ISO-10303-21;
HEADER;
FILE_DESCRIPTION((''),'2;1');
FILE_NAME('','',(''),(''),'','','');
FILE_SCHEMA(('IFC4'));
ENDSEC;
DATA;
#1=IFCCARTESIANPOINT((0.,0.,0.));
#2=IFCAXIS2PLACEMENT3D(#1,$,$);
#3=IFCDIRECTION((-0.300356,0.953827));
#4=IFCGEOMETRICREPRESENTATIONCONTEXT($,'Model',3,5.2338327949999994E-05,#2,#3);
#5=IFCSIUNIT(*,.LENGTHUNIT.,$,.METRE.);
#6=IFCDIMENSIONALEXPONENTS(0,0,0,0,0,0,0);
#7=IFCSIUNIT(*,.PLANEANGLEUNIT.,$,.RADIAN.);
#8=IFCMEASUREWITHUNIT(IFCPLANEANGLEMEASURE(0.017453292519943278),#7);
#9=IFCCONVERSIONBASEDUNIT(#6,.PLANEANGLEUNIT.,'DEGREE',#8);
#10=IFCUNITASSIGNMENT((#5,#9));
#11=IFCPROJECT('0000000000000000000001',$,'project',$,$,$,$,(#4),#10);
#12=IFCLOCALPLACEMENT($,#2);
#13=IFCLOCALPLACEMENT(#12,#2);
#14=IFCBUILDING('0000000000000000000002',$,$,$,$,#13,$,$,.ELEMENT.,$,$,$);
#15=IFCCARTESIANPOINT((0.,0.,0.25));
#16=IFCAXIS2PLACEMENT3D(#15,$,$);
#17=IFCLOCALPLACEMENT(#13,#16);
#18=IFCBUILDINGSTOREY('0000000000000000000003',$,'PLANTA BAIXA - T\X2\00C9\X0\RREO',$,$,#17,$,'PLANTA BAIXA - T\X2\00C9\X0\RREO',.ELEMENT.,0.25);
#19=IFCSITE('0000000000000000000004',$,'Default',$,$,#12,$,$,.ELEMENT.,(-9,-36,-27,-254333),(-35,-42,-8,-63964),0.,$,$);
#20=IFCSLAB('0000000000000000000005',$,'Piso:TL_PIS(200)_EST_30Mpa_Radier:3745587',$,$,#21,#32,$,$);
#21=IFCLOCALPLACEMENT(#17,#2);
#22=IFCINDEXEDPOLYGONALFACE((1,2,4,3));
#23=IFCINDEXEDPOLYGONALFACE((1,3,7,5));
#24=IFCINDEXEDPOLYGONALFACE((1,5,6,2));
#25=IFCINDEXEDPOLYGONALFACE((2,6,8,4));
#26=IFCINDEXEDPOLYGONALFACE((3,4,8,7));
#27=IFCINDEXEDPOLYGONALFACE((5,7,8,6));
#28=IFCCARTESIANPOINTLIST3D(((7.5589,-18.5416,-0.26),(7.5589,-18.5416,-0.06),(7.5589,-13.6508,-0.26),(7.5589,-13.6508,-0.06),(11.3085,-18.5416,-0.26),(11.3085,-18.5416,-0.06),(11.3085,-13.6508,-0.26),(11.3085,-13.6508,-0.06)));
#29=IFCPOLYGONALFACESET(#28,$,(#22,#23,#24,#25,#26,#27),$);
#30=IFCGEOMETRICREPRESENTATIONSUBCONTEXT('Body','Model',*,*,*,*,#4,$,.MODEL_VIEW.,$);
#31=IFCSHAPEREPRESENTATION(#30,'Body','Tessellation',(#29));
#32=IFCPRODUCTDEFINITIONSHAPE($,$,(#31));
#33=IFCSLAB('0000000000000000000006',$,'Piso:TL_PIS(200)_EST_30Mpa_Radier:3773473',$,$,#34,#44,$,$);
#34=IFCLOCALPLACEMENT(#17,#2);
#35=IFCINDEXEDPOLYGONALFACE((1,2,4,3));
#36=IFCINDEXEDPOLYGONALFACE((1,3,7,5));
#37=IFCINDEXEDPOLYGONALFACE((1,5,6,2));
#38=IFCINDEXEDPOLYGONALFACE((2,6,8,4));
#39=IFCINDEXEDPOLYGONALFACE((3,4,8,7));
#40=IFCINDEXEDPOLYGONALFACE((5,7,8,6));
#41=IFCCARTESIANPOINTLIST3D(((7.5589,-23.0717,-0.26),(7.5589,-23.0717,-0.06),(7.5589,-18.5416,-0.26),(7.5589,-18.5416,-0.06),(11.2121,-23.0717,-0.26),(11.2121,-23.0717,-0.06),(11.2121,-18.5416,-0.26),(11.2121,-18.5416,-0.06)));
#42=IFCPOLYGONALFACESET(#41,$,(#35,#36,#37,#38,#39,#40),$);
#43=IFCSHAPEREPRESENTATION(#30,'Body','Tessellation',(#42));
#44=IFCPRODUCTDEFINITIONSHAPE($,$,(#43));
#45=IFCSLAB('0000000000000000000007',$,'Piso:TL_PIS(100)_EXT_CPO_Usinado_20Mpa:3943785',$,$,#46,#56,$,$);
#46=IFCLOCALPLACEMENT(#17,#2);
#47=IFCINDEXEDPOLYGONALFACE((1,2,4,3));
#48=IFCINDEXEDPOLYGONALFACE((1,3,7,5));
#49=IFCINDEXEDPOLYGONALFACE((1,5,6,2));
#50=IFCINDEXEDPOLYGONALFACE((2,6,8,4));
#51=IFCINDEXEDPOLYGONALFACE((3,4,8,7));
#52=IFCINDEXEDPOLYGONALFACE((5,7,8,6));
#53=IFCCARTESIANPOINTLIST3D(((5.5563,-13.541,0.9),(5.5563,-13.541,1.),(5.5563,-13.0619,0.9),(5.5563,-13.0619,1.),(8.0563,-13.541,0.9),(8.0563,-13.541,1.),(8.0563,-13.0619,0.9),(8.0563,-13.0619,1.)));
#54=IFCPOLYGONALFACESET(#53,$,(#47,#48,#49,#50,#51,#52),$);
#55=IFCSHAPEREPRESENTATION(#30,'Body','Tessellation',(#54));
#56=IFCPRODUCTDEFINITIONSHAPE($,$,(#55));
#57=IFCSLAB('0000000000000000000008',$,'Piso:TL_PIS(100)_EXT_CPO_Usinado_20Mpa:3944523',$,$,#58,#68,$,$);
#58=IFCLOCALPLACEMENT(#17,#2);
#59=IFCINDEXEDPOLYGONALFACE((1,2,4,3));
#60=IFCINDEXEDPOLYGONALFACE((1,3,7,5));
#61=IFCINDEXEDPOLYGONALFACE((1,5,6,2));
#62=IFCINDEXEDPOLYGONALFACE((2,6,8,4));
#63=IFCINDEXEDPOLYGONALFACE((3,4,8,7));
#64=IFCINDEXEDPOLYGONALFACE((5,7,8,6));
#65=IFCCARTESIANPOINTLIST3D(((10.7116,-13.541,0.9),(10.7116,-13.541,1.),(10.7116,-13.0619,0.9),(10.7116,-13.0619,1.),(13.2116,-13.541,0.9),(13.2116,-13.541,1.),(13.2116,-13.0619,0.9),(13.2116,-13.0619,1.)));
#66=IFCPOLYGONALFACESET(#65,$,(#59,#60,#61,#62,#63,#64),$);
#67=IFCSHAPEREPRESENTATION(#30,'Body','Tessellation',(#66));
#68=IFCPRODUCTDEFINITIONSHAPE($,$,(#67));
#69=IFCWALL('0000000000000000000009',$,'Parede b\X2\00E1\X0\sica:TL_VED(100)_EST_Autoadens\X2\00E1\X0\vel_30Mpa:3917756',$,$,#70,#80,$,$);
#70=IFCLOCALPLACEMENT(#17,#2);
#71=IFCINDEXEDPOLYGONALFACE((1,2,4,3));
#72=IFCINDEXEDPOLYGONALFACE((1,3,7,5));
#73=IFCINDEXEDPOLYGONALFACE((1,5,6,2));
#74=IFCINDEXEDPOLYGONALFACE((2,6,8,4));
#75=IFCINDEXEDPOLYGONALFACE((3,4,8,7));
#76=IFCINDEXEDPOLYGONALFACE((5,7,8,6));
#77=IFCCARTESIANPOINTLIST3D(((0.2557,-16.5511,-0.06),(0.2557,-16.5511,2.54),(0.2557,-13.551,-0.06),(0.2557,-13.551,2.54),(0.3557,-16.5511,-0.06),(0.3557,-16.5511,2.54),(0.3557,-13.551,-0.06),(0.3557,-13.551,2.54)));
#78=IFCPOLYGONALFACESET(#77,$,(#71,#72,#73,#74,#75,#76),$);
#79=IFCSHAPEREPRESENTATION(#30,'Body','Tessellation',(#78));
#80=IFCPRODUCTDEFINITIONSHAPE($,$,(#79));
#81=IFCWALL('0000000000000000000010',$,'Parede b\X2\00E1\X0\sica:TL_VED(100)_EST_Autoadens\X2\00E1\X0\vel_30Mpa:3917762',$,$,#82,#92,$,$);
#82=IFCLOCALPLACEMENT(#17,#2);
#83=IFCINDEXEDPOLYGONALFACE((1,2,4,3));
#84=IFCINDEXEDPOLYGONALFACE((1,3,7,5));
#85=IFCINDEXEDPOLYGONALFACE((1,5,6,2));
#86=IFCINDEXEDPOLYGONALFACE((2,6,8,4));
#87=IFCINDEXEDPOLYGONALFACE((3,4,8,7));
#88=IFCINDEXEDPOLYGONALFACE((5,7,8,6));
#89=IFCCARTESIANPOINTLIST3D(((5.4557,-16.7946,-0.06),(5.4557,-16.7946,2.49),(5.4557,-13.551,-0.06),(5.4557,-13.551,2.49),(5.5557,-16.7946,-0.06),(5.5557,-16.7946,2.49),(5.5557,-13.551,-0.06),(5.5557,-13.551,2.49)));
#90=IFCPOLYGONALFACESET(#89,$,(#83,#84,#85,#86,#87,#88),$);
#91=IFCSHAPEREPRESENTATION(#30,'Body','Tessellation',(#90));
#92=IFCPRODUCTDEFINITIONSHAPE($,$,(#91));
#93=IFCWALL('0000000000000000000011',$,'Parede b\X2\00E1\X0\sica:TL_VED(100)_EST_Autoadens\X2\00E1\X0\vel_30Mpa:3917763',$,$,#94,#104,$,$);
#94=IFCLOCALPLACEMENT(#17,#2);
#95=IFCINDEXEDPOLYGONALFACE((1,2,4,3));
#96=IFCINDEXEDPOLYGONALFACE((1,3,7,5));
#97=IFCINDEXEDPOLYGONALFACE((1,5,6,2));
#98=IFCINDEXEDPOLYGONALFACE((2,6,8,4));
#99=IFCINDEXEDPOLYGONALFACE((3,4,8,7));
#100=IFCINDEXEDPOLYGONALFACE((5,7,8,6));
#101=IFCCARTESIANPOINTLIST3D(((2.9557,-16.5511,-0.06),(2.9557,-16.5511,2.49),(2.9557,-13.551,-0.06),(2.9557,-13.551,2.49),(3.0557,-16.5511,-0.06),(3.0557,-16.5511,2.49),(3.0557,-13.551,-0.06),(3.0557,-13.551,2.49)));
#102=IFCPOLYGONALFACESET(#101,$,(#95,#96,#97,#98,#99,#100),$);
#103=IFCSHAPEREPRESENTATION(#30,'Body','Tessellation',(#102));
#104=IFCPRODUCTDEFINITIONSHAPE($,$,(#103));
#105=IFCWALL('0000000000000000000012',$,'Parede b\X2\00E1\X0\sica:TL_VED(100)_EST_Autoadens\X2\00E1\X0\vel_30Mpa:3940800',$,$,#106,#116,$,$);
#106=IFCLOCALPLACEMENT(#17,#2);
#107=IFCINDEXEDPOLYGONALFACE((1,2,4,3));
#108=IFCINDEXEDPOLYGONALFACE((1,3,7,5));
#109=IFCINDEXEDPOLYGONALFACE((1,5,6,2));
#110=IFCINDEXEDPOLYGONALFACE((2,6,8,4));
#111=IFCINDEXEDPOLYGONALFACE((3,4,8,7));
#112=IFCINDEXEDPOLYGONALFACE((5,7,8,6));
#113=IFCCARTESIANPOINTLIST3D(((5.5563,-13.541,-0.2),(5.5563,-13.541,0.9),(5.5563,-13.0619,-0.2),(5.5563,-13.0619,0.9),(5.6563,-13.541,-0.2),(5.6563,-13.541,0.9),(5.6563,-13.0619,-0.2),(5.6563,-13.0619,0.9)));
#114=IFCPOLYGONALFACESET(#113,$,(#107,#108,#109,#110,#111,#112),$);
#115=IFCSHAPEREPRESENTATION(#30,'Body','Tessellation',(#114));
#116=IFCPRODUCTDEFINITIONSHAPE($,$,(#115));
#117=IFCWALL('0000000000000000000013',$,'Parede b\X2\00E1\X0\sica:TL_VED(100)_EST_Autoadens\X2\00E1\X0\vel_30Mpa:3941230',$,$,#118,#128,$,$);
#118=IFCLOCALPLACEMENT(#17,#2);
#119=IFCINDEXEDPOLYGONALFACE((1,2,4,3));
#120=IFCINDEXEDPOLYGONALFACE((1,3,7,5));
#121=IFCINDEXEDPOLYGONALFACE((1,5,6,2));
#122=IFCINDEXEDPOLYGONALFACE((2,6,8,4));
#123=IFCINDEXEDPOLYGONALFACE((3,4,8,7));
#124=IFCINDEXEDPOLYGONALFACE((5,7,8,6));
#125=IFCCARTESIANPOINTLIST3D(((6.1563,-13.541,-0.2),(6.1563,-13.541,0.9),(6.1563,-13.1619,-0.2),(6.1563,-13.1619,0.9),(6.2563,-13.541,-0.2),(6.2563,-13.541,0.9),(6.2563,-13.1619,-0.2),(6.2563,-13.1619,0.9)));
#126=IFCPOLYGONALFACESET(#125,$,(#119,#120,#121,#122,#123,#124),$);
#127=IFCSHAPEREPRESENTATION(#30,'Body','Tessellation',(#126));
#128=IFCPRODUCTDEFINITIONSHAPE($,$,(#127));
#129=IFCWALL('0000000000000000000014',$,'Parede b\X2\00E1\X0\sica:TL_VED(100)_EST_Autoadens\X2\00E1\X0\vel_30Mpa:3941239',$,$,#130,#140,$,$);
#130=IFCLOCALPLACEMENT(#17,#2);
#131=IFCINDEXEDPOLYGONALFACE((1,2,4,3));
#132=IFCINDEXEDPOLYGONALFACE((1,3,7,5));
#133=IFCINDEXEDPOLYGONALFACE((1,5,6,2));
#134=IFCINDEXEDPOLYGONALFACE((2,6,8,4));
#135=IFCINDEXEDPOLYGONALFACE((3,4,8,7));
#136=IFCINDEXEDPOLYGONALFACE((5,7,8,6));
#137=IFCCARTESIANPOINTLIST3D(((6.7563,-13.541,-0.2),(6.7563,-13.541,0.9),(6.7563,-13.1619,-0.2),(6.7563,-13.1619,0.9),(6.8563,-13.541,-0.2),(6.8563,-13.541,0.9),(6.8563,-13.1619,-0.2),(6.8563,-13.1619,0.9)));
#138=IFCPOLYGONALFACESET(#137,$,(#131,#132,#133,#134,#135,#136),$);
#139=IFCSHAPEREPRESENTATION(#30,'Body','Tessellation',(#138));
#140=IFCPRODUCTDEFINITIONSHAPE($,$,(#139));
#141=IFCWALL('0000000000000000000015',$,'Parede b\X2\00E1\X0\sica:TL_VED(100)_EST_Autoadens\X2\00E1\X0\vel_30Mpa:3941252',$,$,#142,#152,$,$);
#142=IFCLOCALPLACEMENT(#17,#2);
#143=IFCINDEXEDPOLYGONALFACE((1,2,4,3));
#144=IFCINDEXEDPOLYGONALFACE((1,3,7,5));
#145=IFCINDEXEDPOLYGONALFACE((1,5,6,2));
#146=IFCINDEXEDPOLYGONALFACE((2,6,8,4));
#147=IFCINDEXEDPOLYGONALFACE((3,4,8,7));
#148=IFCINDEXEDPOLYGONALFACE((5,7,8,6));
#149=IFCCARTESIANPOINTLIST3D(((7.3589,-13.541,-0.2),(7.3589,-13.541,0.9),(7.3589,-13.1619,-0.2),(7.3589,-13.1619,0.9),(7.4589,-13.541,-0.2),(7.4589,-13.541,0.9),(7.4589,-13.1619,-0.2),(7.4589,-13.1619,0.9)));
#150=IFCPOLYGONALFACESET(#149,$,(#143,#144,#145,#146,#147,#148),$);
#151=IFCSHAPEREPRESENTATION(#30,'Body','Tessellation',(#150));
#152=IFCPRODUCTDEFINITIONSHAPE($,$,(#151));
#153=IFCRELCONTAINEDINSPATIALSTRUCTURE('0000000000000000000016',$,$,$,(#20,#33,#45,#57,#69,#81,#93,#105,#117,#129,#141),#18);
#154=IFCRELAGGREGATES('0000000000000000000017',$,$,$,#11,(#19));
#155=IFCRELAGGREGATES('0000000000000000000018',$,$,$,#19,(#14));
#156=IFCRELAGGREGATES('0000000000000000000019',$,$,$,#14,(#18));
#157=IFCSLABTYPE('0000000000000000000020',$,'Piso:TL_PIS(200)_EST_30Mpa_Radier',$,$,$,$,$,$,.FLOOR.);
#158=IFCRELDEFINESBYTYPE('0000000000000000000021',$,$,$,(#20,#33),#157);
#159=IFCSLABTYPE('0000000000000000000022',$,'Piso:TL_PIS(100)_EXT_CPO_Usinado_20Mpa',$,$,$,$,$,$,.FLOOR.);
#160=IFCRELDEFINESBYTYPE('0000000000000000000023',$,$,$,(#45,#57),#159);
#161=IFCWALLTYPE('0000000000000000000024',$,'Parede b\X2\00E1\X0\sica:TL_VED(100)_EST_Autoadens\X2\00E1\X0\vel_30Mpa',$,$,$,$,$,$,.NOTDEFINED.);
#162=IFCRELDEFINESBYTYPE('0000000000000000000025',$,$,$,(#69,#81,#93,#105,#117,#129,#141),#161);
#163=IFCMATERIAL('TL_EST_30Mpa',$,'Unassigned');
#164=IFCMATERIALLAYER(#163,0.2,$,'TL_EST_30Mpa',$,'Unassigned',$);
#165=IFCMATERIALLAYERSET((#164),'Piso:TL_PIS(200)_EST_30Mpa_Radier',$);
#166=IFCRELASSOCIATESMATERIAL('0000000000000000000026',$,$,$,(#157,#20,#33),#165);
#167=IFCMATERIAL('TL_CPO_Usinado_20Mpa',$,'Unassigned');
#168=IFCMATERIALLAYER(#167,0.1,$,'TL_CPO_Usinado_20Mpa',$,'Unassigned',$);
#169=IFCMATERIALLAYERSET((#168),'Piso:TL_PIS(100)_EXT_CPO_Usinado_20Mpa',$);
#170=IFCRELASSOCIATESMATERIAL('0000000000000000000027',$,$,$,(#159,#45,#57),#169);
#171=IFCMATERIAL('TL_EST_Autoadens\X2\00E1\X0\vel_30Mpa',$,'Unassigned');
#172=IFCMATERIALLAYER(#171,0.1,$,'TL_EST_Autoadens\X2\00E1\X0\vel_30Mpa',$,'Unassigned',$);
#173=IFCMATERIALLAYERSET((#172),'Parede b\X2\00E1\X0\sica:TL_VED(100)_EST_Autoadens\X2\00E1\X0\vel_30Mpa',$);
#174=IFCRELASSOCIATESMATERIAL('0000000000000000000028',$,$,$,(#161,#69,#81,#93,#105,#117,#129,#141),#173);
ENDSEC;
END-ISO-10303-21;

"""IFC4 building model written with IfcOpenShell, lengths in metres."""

from ifc_helpers import new_model, entity, si_unit, converted_unit, direction, frame, frame_2d, origin, place, context, subcontext, project, spatial, polyline, rectangle, extrude, clip, bounded_halfspace, material, layer, layer_set, layer_usage, type_object, element, save


model = new_model("IFC4")

# Units and contexts
model_context = context("Model", 3, precision=5.2338327949999994e-05, world=origin(), true_north=direction((-0.300356, 0.953827)))
body_context = subcontext(model_context, "Body", "Model", "MODEL_VIEW")
ifc_project = project(units=[si_unit("LENGTHUNIT", "METRE"), converted_unit("PLANEANGLEUNIT", "DEGREE", entity("IfcPlaneAngleMeasure", 0.017453292519943278), si_unit("PLANEANGLEUNIT", "RADIAN"), dimensions=[0, 0, 0, 0, 0, 0, 0])], contexts=[model_context])

# Site, building, storey
site_placement = place(None, origin())
site = spatial("IfcSite", under=ifc_project, at=site_placement, Name="Default", CompositionType="ELEMENT", RefLatitude=(-9, -36, -27, -254333), RefLongitude=(-35, -42, -8, -63964), RefElevation=0.0)
building_placement = place(site_placement, origin())
building = spatial("IfcBuilding", under=site, at=building_placement, CompositionType="ELEMENT")
storey_placement = place(building_placement, frame((0.0, 0.0, 0.25)))
storey = spatial("IfcBuildingStorey", under=building, at=storey_placement, Name="PLANTA BAIXA - TÉRREO", LongName="PLANTA BAIXA - TÉRREO", CompositionType="ELEMENT", Elevation=0.25)

# Slabs
ifc_material_1 = material(Name="TL_EST_30Mpa", Category="Unassigned")
ifc_layer_1 = layer(ifc_material_1, 0.2, Name="TL_EST_30Mpa", Category="Unassigned")
ifc_layer_set_1 = layer_set([ifc_layer_1], Name="Piso:TL_PIS(200)_EST_30Mpa_Radier")
slab_type_1 = type_object("IfcSlabType", Name="Piso:TL_PIS(200)_EST_30Mpa_Radier", PredefinedType="FLOOR", material=ifc_layer_set_1)
ifc_layer_usage_1 = layer_usage(ifc_layer_set_1, "AXIS3", "POSITIVE", 0.0)
slab_1_placement = place(storey_placement, origin())
element("IfcSlab", 1, at=slab_1_placement, inside=storey, type_object=slab_type_1, material=ifc_layer_usage_1, Name="Piso:TL_PIS(200)_EST_30Mpa_Radier:3745587", context=body_context, shape_type="SweptSolid", body=[
    extrude(rectangle(XDim=4.8908, YDim=3.7495, at=frame_2d((0.0, 0.0), x_axis=(1.0, 0.0))), frame((9.4337, -16.0962, -0.06), z_axis=(0.0, 0.0, -1.0), x_axis=(0.0, 1.0, 0.0)), (0.0, 0.0, 1.0), 0.2),
])
ifc_layer_usage_2 = layer_usage(ifc_layer_set_1, "AXIS3", "POSITIVE", 0.0)
slab_2_placement = place(storey_placement, origin())
element("IfcSlab", 2, at=slab_2_placement, inside=storey, type_object=slab_type_1, material=ifc_layer_usage_2, Name="Piso:TL_PIS(200)_EST_30Mpa_Radier:3773473", context=body_context, shape_type="SweptSolid", body=[
    extrude(rectangle(XDim=4.5301, YDim=3.6532, at=frame_2d((0.0, 0.0), x_axis=(1.0, 0.0))), frame((9.3855, -20.8067, -0.06), z_axis=(0.0, 0.0, -1.0), x_axis=(0.0, 1.0, 0.0)), (0.0, 0.0, 1.0), 0.2),
])
ifc_material_2 = material(Name="TL_CPO_Usinado_20Mpa", Category="Unassigned")
ifc_layer_2 = layer(ifc_material_2, 0.1, Name="TL_CPO_Usinado_20Mpa", Category="Unassigned")
ifc_layer_set_2 = layer_set([ifc_layer_2], Name="Piso:TL_PIS(100)_EXT_CPO_Usinado_20Mpa")
slab_type_2 = type_object("IfcSlabType", Name="Piso:TL_PIS(100)_EXT_CPO_Usinado_20Mpa", PredefinedType="FLOOR", material=ifc_layer_set_2)
ifc_layer_usage_3 = layer_usage(ifc_layer_set_2, "AXIS3", "POSITIVE", 0.0)
slab_3_placement = place(storey_placement, origin())
element("IfcSlab", 3, at=slab_3_placement, inside=storey, type_object=slab_type_2, material=ifc_layer_usage_3, Name="Piso:TL_PIS(100)_EXT_CPO_Usinado_20Mpa:3943785", context=body_context, shape_type="SweptSolid", body=[
    extrude(rectangle(XDim=0.4791, YDim=2.5, at=frame_2d((0.0, 0.0), x_axis=(1.0, 0.0))), frame((6.8063, -13.3014, 1.0), z_axis=(0.0, 0.0, -1.0), x_axis=(0.0, 1.0, 0.0)), (0.0, 0.0, 1.0), 0.1),
])
ifc_layer_usage_4 = layer_usage(ifc_layer_set_2, "AXIS3", "POSITIVE", 0.0)
slab_4_placement = place(storey_placement, origin())
element("IfcSlab", 4, at=slab_4_placement, inside=storey, type_object=slab_type_2, material=ifc_layer_usage_4, Name="Piso:TL_PIS(100)_EXT_CPO_Usinado_20Mpa:3944523", context=body_context, shape_type="SweptSolid", body=[
    extrude(rectangle(XDim=0.4791, YDim=2.5, at=frame_2d((0.0, 0.0), x_axis=(1.0, 0.0))), frame((11.9616, -13.3014, 1.0), z_axis=(0.0, 0.0, -1.0), x_axis=(0.0, 1.0, 0.0)), (0.0, 0.0, 1.0), 0.1),
])

# Walls
ifc_material_3 = material(Name="TL_EST_Autoadensável_30Mpa", Category="Unassigned")
ifc_layer_3 = layer(ifc_material_3, 0.1, Name="TL_EST_Autoadensável_30Mpa", Category="Unassigned")
ifc_layer_set_3 = layer_set([ifc_layer_3], Name="Parede básica:TL_VED(100)_EST_Autoadensável_30Mpa")
ifc_layer_usage_5 = layer_usage(ifc_layer_set_3, "AXIS2", "NEGATIVE", 0.05)
wall_type_1 = type_object("IfcWallType", Name="Parede básica:TL_VED(100)_EST_Autoadensável_30Mpa", PredefinedType="NOTDEFINED", material=ifc_layer_set_3)
wall_1_placement = place(storey_placement, frame((0.3057, -13.551, -0.06), z_axis=(0.0, 0.0, 1.0), x_axis=(0.0, -1.0, 0.0)))
element("IfcWall", 5, at=wall_1_placement, inside=storey, type_object=wall_type_1, material=ifc_layer_usage_5, Name="Parede básica:TL_VED(100)_EST_Autoadensável_30Mpa:3917756", context=body_context, shape_type="SweptSolid", body=[
    extrude(rectangle(XDim=3.0001, YDim=0.1, at=frame_2d((1.5001, 0.0), x_axis=(-1.0, 0.0))), origin(), (0.0, 0.0, 1.0), 2.6),
])
ifc_layer_usage_6 = layer_usage(ifc_layer_set_3, "AXIS2", "NEGATIVE", 0.05)
wall_2_placement = place(storey_placement, frame((5.5057, -13.551, -0.06), z_axis=(0.0, 0.0, 1.0), x_axis=(0.0, -1.0, 0.0)))
element("IfcWall", 6, at=wall_2_placement, inside=storey, type_object=wall_type_1, material=ifc_layer_usage_6, Name="Parede básica:TL_VED(100)_EST_Autoadensável_30Mpa:3917762", context=body_context, shape_type="SweptSolid", body=[
    extrude(rectangle(XDim=3.2437, YDim=0.1, at=frame_2d((1.6218, 0.0), x_axis=(-1.0, 0.0))), origin(), (0.0, 0.0, 1.0), 2.55),
])

# Wall, opening
ifc_layer_usage_7 = layer_usage(ifc_layer_set_3, "AXIS2", "NEGATIVE", 0.05)
wall_3_placement = place(storey_placement, frame((3.0057, -13.551, -0.06), z_axis=(0.0, 0.0, 1.0), x_axis=(0.0, -1.0, 0.0)))
wall_3 = element("IfcWall", 7, at=wall_3_placement, inside=storey, type_object=wall_type_1, material=ifc_layer_usage_7, Name="Parede básica:TL_VED(100)_EST_Autoadensável_30Mpa:3917763", context=body_context, shape_type="SweptSolid", body=[
    extrude(rectangle(XDim=3.0001, YDim=0.1, at=frame_2d((1.5001, 0.0), x_axis=(-1.0, 0.0))), origin(), (0.0, 0.0, 1.0), 2.55),
])
opening_1_placement = place(wall_3_placement, frame((-13.551, -3.0057, 0.06)))
element("IfcOpeningElement", 8, at=opening_1_placement, cuts=wall_3, PredefinedType="OPENING", context=body_context, shape_type="SweptSolid", body=[
    extrude(rectangle(XDim=2.1, YDim=0.1, at=frame_2d((0.0, 0.0), x_axis=(0.0, 1.0))), frame((14.501, 3.0557, 1.05), z_axis=(0.0, 1.0, 0.0), x_axis=(1.0, 0.0, 0.0)), (0.0, 0.0, 1.0), 2.4),
])

# Walls
ifc_layer_usage_8 = layer_usage(ifc_layer_set_3, "AXIS2", "NEGATIVE", 0.05)
wall_4_placement = place(storey_placement, frame((5.6063, -13.0619, -0.2), z_axis=(0.0, 0.0, 1.0), x_axis=(0.0, -1.0, 0.0)))
element("IfcWall", 9, at=wall_4_placement, inside=storey, type_object=wall_type_1, material=ifc_layer_usage_8, Name="Parede básica:TL_VED(100)_EST_Autoadensável_30Mpa:3940800", context=body_context, shape_type="Clipping", body=[
    clip(extrude(rectangle(XDim=0.4791, YDim=0.1, at=frame_2d((0.2395, 0.0), x_axis=(-1.0, 0.0))), origin(), (0.0, 0.0, 1.0), 1.1), bounded_halfspace(frame((0.0, -0.05, 1.1), z_axis=(0.0, 0.0, -1.0), x_axis=(1.0, 0.0, 0.0)), True, frame((0.0, -0.05, 1.1)), polyline([(0.0, 0.0), (0.4791, 0.0), (0.4791, 0.1), (0.1, 0.1), (0.0, 0.1), (0.0, 0.0)]))),
])
ifc_layer_usage_9 = layer_usage(ifc_layer_set_3, "AXIS2", "NEGATIVE", 0.05)
wall_5_placement = place(storey_placement, frame((6.2063, -13.1619, -0.2), z_axis=(0.0, 0.0, 1.0), x_axis=(0.0, -1.0, 0.0)))
element("IfcWall", 10, at=wall_5_placement, inside=storey, type_object=wall_type_1, material=ifc_layer_usage_9, Name="Parede básica:TL_VED(100)_EST_Autoadensável_30Mpa:3941230", context=body_context, shape_type="Clipping", body=[
    clip(extrude(rectangle(XDim=0.3791, YDim=0.1, at=frame_2d((0.1895, 0.0), x_axis=(-1.0, 0.0))), origin(), (0.0, 0.0, 1.0), 1.1), bounded_halfspace(frame((0.0, -0.05, 1.1), z_axis=(0.0, 0.0, -1.0), x_axis=(1.0, 0.0, 0.0)), True, frame((0.0, -0.05, 1.1)), polyline([(0.0, 0.0), (0.3791, 0.0), (0.3791, 0.1), (0.0, 0.1), (0.0, 0.0)]))),
])
ifc_layer_usage_10 = layer_usage(ifc_layer_set_3, "AXIS2", "NEGATIVE", 0.05)
wall_6_placement = place(storey_placement, frame((6.8063, -13.1619, -0.2), z_axis=(0.0, 0.0, 1.0), x_axis=(0.0, -1.0, 0.0)))
element("IfcWall", 11, at=wall_6_placement, inside=storey, type_object=wall_type_1, material=ifc_layer_usage_10, Name="Parede básica:TL_VED(100)_EST_Autoadensável_30Mpa:3941239", context=body_context, shape_type="Clipping", body=[
    clip(extrude(rectangle(XDim=0.3791, YDim=0.1, at=frame_2d((0.1895, 0.0), x_axis=(-1.0, 0.0))), origin(), (0.0, 0.0, 1.0), 1.1), bounded_halfspace(frame((0.0, -0.05, 1.1), z_axis=(0.0, 0.0, -1.0), x_axis=(1.0, 0.0, 0.0)), True, frame((0.0, -0.05, 1.1)), polyline([(0.0, 0.0), (0.3791, 0.0), (0.3791, 0.1), (0.0, 0.1), (0.0, 0.0)]))),
])
ifc_layer_usage_11 = layer_usage(ifc_layer_set_3, "AXIS2", "NEGATIVE", 0.05)
wall_7_placement = place(storey_placement, frame((7.4089, -13.1619, -0.2), z_axis=(0.0, 0.0, 1.0), x_axis=(0.0, -1.0, 0.0)))
element("IfcWall", 12, at=wall_7_placement, inside=storey, type_object=wall_type_1, material=ifc_layer_usage_11, Name="Parede básica:TL_VED(100)_EST_Autoadensável_30Mpa:3941252", context=body_context, shape_type="Clipping", body=[
    clip(extrude(rectangle(XDim=0.3791, YDim=0.1, at=frame_2d((0.1895, 0.0), x_axis=(-1.0, 0.0))), origin(), (0.0, 0.0, 1.0), 1.1), bounded_halfspace(frame((0.0, -0.05, 1.1), z_axis=(0.0, 0.0, -1.0), x_axis=(1.0, 0.0, 0.0)), True, frame((0.0, -0.05, 1.1)), polyline([(0.0, 0.0), (0.3791, 0.0), (0.3791, 0.1), (0.0, 0.1), (0.0, 0.0)]))),
])

save(model, "model.ifc")
